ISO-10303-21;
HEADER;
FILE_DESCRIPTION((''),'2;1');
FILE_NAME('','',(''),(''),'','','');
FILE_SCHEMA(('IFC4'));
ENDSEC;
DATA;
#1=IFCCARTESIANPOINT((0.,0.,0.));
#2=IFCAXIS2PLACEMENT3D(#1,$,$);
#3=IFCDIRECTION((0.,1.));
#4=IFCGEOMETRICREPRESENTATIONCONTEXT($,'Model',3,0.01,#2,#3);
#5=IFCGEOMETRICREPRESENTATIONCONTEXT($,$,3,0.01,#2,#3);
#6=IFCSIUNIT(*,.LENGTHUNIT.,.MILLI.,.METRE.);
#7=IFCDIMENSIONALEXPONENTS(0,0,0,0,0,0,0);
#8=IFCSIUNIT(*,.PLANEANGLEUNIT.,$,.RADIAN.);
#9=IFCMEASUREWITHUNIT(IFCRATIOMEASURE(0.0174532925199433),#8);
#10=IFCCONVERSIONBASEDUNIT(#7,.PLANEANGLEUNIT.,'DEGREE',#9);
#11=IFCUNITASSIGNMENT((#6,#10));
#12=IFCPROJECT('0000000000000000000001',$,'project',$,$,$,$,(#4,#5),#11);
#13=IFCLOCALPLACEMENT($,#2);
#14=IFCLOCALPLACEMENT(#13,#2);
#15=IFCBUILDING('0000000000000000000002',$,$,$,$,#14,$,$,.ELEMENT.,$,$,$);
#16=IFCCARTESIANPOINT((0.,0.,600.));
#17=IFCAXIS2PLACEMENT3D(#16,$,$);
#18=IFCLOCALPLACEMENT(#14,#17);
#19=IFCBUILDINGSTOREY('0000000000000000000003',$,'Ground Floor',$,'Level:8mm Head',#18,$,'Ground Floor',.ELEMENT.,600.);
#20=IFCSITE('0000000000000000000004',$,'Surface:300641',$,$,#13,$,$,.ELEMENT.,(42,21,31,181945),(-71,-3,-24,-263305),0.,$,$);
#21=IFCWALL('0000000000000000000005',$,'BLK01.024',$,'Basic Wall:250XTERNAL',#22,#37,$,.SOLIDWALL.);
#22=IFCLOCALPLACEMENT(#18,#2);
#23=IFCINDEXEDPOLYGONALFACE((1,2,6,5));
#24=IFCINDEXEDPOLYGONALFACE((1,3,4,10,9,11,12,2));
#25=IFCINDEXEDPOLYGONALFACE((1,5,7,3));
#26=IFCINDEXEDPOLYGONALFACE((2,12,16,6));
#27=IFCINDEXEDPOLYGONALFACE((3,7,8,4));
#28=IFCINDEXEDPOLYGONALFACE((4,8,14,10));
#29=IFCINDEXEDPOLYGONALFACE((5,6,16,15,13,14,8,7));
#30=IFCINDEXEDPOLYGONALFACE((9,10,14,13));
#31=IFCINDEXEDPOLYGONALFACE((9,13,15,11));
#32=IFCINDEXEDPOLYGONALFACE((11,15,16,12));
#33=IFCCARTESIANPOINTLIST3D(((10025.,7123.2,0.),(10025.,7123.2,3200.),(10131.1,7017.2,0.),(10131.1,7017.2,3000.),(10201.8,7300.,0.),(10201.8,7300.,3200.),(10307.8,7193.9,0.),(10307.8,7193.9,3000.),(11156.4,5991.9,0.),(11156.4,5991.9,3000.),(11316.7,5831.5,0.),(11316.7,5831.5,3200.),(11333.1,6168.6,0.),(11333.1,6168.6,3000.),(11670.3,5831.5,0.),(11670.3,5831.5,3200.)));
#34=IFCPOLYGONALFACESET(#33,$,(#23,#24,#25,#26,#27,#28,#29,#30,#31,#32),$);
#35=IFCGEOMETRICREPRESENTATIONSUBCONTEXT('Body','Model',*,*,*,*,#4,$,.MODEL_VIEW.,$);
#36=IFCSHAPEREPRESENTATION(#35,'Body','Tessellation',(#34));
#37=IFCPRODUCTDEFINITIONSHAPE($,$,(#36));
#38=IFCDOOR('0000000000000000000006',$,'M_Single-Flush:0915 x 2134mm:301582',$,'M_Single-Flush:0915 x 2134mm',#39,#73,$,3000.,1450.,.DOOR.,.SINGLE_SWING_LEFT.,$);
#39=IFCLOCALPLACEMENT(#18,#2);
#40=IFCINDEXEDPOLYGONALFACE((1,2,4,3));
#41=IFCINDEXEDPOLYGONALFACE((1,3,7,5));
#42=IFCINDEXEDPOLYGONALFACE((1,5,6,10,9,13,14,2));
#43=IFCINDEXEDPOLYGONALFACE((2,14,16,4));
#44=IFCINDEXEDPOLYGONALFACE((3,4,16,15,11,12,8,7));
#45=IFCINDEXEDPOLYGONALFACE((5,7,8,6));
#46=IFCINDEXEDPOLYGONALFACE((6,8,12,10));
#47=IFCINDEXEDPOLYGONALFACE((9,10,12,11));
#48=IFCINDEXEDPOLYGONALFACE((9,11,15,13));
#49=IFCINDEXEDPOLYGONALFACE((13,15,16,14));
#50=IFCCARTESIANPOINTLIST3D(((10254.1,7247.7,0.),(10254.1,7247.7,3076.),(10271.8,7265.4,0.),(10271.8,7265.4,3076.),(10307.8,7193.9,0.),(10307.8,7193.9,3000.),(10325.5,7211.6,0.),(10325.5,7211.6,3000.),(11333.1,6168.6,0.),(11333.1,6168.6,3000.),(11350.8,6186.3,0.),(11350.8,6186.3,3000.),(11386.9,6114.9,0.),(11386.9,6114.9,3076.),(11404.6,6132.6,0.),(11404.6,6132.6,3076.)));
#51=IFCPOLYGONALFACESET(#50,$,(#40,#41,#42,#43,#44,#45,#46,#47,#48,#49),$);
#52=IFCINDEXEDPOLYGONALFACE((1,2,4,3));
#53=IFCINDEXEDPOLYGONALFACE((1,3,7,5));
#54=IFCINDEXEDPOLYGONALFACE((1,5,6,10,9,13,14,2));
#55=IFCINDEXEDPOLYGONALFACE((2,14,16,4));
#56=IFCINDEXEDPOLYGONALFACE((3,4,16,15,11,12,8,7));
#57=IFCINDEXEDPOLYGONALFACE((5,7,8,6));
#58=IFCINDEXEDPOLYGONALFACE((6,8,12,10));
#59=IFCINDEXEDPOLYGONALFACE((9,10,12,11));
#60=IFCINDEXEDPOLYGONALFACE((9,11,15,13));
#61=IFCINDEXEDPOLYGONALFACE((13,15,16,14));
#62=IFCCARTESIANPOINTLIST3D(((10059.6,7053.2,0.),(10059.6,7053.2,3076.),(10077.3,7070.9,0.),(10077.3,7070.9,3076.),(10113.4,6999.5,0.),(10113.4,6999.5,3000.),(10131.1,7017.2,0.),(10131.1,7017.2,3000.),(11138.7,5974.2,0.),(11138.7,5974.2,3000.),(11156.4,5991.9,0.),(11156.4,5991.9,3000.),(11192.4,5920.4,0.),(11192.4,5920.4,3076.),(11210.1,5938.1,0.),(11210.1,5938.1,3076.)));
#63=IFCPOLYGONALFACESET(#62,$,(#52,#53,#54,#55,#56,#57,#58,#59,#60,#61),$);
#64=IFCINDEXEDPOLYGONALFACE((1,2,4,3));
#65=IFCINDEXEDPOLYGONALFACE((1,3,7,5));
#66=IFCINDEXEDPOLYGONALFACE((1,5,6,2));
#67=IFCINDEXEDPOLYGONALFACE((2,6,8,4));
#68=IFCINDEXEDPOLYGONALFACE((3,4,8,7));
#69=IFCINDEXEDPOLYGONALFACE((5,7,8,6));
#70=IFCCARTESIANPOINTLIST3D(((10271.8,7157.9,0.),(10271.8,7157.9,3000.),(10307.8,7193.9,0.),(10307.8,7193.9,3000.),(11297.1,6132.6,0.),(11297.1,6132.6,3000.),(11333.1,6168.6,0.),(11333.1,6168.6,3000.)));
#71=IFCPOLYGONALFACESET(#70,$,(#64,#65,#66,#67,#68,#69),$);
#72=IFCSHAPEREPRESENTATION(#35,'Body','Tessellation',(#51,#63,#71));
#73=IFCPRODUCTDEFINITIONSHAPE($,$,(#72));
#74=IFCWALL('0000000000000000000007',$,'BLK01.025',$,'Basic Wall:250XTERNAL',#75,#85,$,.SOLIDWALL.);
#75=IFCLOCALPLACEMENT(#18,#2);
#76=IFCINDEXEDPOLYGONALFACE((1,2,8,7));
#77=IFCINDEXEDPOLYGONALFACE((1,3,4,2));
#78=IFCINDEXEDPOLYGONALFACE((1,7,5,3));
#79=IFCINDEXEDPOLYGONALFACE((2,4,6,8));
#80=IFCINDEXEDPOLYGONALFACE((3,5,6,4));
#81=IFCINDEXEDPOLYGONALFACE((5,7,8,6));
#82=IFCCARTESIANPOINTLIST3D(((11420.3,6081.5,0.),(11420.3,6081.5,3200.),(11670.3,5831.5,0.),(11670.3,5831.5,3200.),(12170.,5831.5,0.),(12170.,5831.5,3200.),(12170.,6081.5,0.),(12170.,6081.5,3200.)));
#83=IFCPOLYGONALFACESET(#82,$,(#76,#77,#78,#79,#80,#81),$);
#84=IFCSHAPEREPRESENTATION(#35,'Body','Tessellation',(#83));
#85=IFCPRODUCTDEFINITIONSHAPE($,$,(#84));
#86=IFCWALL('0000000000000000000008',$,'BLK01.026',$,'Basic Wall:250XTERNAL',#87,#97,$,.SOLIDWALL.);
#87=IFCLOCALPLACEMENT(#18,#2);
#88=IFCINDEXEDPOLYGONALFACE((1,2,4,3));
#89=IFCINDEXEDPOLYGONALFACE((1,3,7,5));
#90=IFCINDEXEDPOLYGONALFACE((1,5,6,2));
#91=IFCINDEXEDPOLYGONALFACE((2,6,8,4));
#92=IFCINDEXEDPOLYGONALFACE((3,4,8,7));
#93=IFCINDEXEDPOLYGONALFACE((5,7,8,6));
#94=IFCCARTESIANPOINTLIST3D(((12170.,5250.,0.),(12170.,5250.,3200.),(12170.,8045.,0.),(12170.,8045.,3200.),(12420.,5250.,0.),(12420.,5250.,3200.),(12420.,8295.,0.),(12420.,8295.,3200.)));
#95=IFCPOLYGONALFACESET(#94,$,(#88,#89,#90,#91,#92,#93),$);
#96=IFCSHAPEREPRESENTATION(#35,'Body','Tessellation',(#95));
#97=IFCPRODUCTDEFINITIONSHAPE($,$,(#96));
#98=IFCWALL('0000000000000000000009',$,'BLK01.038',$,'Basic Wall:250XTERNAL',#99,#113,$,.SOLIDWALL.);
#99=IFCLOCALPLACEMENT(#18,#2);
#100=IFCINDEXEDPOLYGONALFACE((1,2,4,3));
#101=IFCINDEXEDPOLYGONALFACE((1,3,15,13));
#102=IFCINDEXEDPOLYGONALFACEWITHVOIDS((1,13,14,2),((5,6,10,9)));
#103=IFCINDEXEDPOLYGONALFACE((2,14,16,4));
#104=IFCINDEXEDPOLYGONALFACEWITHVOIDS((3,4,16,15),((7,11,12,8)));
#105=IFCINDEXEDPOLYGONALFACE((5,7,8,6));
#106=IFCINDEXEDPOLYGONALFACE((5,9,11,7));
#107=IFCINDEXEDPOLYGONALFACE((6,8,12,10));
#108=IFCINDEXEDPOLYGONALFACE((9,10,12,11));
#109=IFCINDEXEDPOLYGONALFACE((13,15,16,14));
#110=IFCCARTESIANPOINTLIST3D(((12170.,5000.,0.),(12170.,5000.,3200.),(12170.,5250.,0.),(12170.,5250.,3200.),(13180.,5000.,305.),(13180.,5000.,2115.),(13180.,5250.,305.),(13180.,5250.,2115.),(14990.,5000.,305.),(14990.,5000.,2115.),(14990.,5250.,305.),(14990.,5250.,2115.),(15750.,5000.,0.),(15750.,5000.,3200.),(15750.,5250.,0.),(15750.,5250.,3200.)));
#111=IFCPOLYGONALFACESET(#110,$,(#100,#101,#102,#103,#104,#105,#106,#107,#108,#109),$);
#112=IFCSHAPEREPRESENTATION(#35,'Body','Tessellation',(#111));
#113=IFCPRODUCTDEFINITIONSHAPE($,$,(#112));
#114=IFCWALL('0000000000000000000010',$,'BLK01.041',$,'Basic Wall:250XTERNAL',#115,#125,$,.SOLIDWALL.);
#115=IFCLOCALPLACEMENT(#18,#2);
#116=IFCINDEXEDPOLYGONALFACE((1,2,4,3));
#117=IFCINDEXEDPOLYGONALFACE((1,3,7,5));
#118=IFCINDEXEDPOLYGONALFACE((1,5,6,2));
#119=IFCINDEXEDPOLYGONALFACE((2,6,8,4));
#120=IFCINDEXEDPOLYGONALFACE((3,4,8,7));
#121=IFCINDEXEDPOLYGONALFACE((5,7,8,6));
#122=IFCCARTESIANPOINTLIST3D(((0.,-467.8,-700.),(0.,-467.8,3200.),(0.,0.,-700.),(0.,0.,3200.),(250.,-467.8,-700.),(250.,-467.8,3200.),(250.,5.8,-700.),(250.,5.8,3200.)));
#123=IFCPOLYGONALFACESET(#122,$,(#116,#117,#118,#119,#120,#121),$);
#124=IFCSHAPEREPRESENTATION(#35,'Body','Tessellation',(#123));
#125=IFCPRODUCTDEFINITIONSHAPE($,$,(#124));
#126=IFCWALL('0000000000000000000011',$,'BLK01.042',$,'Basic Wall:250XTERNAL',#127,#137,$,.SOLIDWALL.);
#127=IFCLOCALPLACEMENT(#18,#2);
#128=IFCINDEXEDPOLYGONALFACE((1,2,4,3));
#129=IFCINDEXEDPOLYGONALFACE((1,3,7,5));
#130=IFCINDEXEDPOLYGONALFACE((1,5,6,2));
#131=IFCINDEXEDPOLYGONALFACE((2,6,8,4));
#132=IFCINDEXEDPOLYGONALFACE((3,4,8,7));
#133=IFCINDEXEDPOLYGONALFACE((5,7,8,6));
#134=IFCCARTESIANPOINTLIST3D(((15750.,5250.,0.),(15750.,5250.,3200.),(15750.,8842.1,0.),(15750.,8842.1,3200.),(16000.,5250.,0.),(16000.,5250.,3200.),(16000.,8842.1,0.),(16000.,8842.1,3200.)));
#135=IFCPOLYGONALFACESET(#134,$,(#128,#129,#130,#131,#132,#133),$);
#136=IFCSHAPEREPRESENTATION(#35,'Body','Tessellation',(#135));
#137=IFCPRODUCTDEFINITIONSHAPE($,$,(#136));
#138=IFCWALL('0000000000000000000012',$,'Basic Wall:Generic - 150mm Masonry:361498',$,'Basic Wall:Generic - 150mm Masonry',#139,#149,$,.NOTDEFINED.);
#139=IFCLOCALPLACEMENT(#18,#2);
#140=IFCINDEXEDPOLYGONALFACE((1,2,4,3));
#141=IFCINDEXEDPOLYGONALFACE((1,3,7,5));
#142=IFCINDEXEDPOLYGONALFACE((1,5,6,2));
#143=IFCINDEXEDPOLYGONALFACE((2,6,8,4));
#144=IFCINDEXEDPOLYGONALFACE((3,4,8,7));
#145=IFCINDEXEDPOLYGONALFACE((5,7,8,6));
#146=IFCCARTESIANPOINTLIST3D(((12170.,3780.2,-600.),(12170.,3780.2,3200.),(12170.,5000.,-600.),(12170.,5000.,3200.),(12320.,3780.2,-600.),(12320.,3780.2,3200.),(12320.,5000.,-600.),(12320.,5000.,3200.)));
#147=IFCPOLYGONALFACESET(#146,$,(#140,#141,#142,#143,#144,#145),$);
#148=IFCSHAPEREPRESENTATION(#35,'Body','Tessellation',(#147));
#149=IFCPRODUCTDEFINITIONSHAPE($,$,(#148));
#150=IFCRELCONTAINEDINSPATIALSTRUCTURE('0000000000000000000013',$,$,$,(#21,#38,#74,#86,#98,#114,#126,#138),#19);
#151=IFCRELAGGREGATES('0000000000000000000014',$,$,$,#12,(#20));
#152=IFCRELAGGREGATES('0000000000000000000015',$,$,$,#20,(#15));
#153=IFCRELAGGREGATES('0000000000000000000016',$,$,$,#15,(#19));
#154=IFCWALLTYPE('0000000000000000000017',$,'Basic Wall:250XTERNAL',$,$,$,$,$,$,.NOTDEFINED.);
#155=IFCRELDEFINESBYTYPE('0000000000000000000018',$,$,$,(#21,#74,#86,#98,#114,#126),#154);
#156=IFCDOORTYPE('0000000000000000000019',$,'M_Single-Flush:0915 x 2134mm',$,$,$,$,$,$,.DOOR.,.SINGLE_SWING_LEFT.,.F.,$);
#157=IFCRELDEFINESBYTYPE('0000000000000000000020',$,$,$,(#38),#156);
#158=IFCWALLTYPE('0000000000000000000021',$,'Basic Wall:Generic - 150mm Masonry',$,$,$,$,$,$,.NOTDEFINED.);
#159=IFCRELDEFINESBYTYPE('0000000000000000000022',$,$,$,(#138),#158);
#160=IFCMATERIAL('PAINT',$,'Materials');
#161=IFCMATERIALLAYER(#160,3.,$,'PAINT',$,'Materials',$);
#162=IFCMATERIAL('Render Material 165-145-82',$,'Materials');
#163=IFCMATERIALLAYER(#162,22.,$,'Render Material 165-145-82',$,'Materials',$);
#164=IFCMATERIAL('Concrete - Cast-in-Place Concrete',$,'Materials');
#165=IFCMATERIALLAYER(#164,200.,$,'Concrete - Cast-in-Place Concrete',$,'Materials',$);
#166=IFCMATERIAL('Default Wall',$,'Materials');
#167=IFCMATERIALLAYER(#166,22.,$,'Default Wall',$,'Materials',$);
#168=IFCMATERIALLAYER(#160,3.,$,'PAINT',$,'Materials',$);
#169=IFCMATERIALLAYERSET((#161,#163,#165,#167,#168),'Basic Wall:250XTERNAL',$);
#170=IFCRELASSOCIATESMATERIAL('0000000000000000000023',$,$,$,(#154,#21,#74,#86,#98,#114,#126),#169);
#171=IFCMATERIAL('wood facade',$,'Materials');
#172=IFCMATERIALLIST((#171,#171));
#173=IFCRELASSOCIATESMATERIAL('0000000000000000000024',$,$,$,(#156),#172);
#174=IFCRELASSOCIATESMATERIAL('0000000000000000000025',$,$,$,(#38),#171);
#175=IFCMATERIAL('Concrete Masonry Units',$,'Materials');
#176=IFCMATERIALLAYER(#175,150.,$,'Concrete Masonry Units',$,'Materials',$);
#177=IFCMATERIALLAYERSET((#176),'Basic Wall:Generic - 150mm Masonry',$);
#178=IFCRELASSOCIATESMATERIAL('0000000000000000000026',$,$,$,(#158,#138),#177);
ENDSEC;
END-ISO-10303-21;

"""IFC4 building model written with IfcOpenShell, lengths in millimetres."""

from ifc_helpers import new_model, entity, si_unit, converted_unit, direction, frame, frame_2d, origin, place, context, subcontext, project, spatial, polyline, rectangle, outline, extrude, clip, halfspace, source, transform, mapped, material, material_list, layer, layer_set, layer_usage, type_object, type_shapes, element, fill, save


model = new_model("IFC4")

# Units and contexts
model_context = context("Model", 3, precision=0.01, world=origin(), true_north=direction((0.0, 1.0)))
context_of_model = context(None, 3, precision=0.01, world=origin(), true_north=direction((0.0, 1.0)))
body_context = subcontext(model_context, "Body", "Model", "MODEL_VIEW")
ifc_project = project(units=[si_unit("LENGTHUNIT", "METRE", prefix="MILLI"), converted_unit("PLANEANGLEUNIT", "DEGREE", entity("IfcRatioMeasure", 0.0174532925199433), si_unit("PLANEANGLEUNIT", "RADIAN"), dimensions=[0, 0, 0, 0, 0, 0, 0])], contexts=[model_context, context_of_model])

# Site, building, storey
site_placement = place(None, origin())
site = spatial("IfcSite", under=ifc_project, at=site_placement, Name="Surface:300641", CompositionType="ELEMENT", RefLatitude=(42, 21, 31, 181945), RefLongitude=(-71, -3, -24, -263305), RefElevation=0.0)
building_placement = place(site_placement, origin())
building = spatial("IfcBuilding", under=site, at=building_placement, CompositionType="ELEMENT")
storey_placement = place(building_placement, frame((0.0, 0.0, 600.0)))
storey = spatial("IfcBuildingStorey", under=building, at=storey_placement, Name="Ground Floor", ObjectType="Level:8mm Head", LongName="Ground Floor", CompositionType="ELEMENT", Elevation=600.0)

# Shared definitions
ifc_material_1 = material(Name="Concrete - Cast-in-Place Concrete", Category="Materials")

# Shared definitions
ifc_material_2 = material(Name="PAINT", Category="Materials")
ifc_layer_1 = layer(ifc_material_2, 3.0, Name="PAINT", Category="Materials")
ifc_material_3 = material(Name="Render Material 165-145-82", Category="Materials")
ifc_layer_2 = layer(ifc_material_3, 22.0, Name="Render Material 165-145-82", Category="Materials")
ifc_layer_3 = layer(ifc_material_1, 200.0, Name="Concrete - Cast-in-Place Concrete", Category="Materials")
ifc_material_4 = material(Name="Default Wall", Category="Materials")
ifc_layer_4 = layer(ifc_material_4, 22.0, Name="Default Wall", Category="Materials")
ifc_layer_5 = layer(ifc_material_2, 3.0, Name="PAINT", Category="Materials")
ifc_layer_set_1 = layer_set([ifc_layer_1, ifc_layer_2, ifc_layer_3, ifc_layer_4, ifc_layer_5], Name="Basic Wall:250XTERNAL")
wall_type_1 = type_object("IfcWallType", Name="Basic Wall:250XTERNAL", PredefinedType="NOTDEFINED", material=ifc_layer_set_1)

# Wall, opening, door
ifc_layer_usage_1 = layer_usage(ifc_layer_set_1, "AXIS2", "NEGATIVE", 125.0)
wall_1_placement = place(storey_placement, frame((10113.4, 7211.6, 0.0), z_axis=(0.0, 0.0, 1.0), x_axis=(0.707107, -0.707107, 0.0)))
wall_1 = element("IfcWall", 1, at=wall_1_placement, inside=storey, type_object=wall_type_1, material=ifc_layer_usage_1, Name="BLK01.024", ObjectType="Basic Wall:250XTERNAL", PredefinedType="SOLIDWALL", context=body_context, shape_type="Clipping", body=[
    clip(extrude(outline(polyline([(0.0, -125.0), (1826.8, -125.0), (2076.8, 125.0), (1723.2, 125.0), (0.0, 125.0), (0.0, -125.0)])), origin(), (0.0, 0.0, 1.0), 3200.0), halfspace(origin(), True)),
])
opening_1_placement = place(wall_1_placement, frame((150.0, -125.0, 0.0)))
opening_1 = element("IfcOpeningElement", 2, at=opening_1_placement, cuts=wall_1, ObjectType="Opening", PredefinedType="OPENING", context=body_context, shape_type="SweptSolid", body=[
    extrude(rectangle(XDim=1450.0, YDim=3000.0, at=frame_2d((1500.0, 725.0), x_axis=(0.0, -1.0))), frame((0.0, 0.0, 0.0), z_axis=(0.0, 1.0, 0.0), x_axis=(0.0, 0.0, 1.0)), (0.0, 0.0, 1.0), 250.0),
])
ifc_material_5 = material(Name="wood facade", Category="Materials")
ifc_material_list = material_list([ifc_material_5, ifc_material_5])
door_type = type_object("IfcDoorType", Name="M_Single-Flush:0915 x 2134mm", OperationType="SINGLE_SWING_LEFT", ParameterTakesPrecedence=False, PredefinedType="DOOR", material=ifc_material_list)
shared_shape_1 = source(origin(), body_context, "Body", "SweptSolid", [
    extrude(outline(polyline([(-801.0, -1557.0), (801.0, -1557.0), (801.0, 1519.0), (725.0, 1519.0), (725.0, -1481.0), (-725.0, -1481.0), (-725.0, 1519.0), (-801.0, 1519.0), (-801.0, -1557.0)])), frame((725.0, 275.0, 1519.0), z_axis=(0.0, -1.0, 0.0), x_axis=(-1.0, 0.0, 0.0)), (0.0, 0.0, 1.0), 25.0),
    extrude(outline(polyline([(-1557.0, -801.0), (1519.0, -801.0), (1519.0, -725.0), (-1481.0, -725.0), (-1481.0, 725.0), (1519.0, 725.0), (1519.0, 801.0), (-1557.0, 801.0), (-1557.0, -801.0)])), frame((725.0, 0.0, 1519.0), z_axis=(0.0, -1.0, 0.0), x_axis=(0.0, 0.0, -1.0)), (0.0, 0.0, 1.0), 25.0),
    extrude(rectangle(XDim=1450.0, YDim=51.0, at=frame_2d((0.0, 0.0), x_axis=(1.0, 0.0))), frame((725.0, 224.5, 0.0)), (0.0, 0.0, 1.0), 3000.0),
])
type_shapes(door_type, [shared_shape_1])
door_placement = place(opening_1_placement, origin())
door = element("IfcDoor", 3, at=door_placement, inside=storey, type_object=door_type, material=ifc_material_5, Name="M_Single-Flush:0915 x 2134mm:301582", ObjectType="M_Single-Flush:0915 x 2134mm", OperationType="SINGLE_SWING_LEFT", OverallHeight=3000.0, OverallWidth=1450.0, PredefinedType="DOOR", context=body_context, shape_type="MappedRepresentation", body=[
    mapped(shared_shape_1, transform((0.0, 0.0, 0.0), scale=1.0)),
])
fill(opening_1, door)

# Walls
ifc_layer_usage_2 = layer_usage(ifc_layer_set_1, "AXIS2", "NEGATIVE", 125.0)
wall_2_placement = place(storey_placement, frame((11420.3, 5956.5, 0.0)))
element("IfcWall", 4, at=wall_2_placement, inside=storey, type_object=wall_type_1, material=ifc_layer_usage_2, Name="BLK01.025", ObjectType="Basic Wall:250XTERNAL", PredefinedType="SOLIDWALL", context=body_context, shape_type="Clipping", body=[
    clip(extrude(outline(polyline([(749.7, -125.0), (749.7, 125.0), (0.0, 125.0), (250.0, -125.0), (749.7, -125.0)])), origin(), (0.0, 0.0, 1.0), 3200.0), halfspace(origin(), True)),
])
ifc_layer_usage_3 = layer_usage(ifc_layer_set_1, "AXIS2", "NEGATIVE", 125.0)
wall_3_placement = place(storey_placement, frame((12295.0, 5250.0, 0.0), z_axis=(0.0, 0.0, 1.0), x_axis=(0.0, 1.0, 0.0)))
element("IfcWall", 5, at=wall_3_placement, inside=storey, type_object=wall_type_1, material=ifc_layer_usage_3, Name="BLK01.026", ObjectType="Basic Wall:250XTERNAL", PredefinedType="SOLIDWALL", context=body_context, shape_type="Clipping", body=[
    clip(extrude(outline(polyline([(3045.0, -125.0), (2795.0, 125.0), (831.5, 125.0), (581.5, 125.0), (0.0, 125.0), (0.0, -125.0), (2691.4, -125.0), (3045.0, -125.0)])), origin(), (0.0, 0.0, 1.0), 3200.0), halfspace(origin(), True)),
])

# Wall, opening
ifc_layer_usage_4 = layer_usage(ifc_layer_set_1, "AXIS2", "NEGATIVE", 125.0)
wall_4_placement = place(storey_placement, frame((12170.0, 5125.0, 0.0)))
wall_4 = element("IfcWall", 6, at=wall_4_placement, inside=storey, type_object=wall_type_1, material=ifc_layer_usage_4, Name="BLK01.038", ObjectType="Basic Wall:250XTERNAL", PredefinedType="SOLIDWALL", context=body_context, shape_type="Clipping", body=[
    clip(extrude(rectangle(XDim=3580.0, YDim=250.0, at=frame_2d((1790.0, 0.0), x_axis=(-1.0, 0.0))), origin(), (0.0, 0.0, 1.0), 3200.0), halfspace(origin(), True)),
])
opening_2_placement = place(wall_4_placement, frame((1010.0, -125.0, 305.0)))
element("IfcOpeningElement", 7, at=opening_2_placement, cuts=wall_4, ObjectType="Opening", PredefinedType="OPENING", context=body_context, shape_type="SweptSolid", body=[
    extrude(rectangle(XDim=1810.0, YDim=1810.0, at=frame_2d((905.0, 905.0), x_axis=(-1.0, 0.0))), frame((0.0, 0.0, 0.0), z_axis=(0.0, 1.0, 0.0), x_axis=(0.0, 0.0, 1.0)), (0.0, 0.0, 1.0), 250.0),
])

# Walls
ifc_layer_usage_5 = layer_usage(ifc_layer_set_1, "AXIS2", "NEGATIVE", 125.0)
wall_5_placement = place(storey_placement, frame((125.0, 5.8, -700.0), z_axis=(0.0, 0.0, 1.0), x_axis=(0.0, -1.0, 0.0)))
element("IfcWall", 8, at=wall_5_placement, inside=storey, type_object=wall_type_1, material=ifc_layer_usage_5, Name="BLK01.041", ObjectType="Basic Wall:250XTERNAL", PredefinedType="SOLIDWALL", context=body_context, shape_type="SweptSolid", body=[
    extrude(outline(polyline([(473.5, -125.0), (473.5, 125.0), (0.0, 125.0), (5.8, -125.0), (473.5, -125.0)])), origin(), (0.0, 0.0, 1.0), 3900.0),
])
ifc_layer_usage_6 = layer_usage(ifc_layer_set_1, "AXIS2", "NEGATIVE", 125.0)
wall_6_placement = place(storey_placement, frame((15875.0, 5250.0, 0.0), z_axis=(0.0, 0.0, 1.0), x_axis=(0.0, 1.0, 0.0)))
element("IfcWall", 9, at=wall_6_placement, inside=storey, type_object=wall_type_1, material=ifc_layer_usage_6, Name="BLK01.042", ObjectType="Basic Wall:250XTERNAL", PredefinedType="SOLIDWALL", context=body_context, shape_type="Clipping", body=[
    clip(extrude(rectangle(XDim=3592.1, YDim=250.0, at=frame_2d((1796.1, 0.0), x_axis=(-1.0, 0.0))), origin(), (0.0, 0.0, 1.0), 3200.0), halfspace(origin(), True)),
])
ifc_material_6 = material(Name="Concrete Masonry Units", Category="Materials")
ifc_layer_6 = layer(ifc_material_6, 150.0, Name="Concrete Masonry Units", Category="Materials")
ifc_layer_set_2 = layer_set([ifc_layer_6], Name="Basic Wall:Generic - 150mm Masonry")
ifc_layer_usage_7 = layer_usage(ifc_layer_set_2, "AXIS2", "NEGATIVE", 75.0)
wall_type_2 = type_object("IfcWallType", Name="Basic Wall:Generic - 150mm Masonry", PredefinedType="NOTDEFINED", material=ifc_layer_set_2)
wall_7_placement = place(storey_placement, frame((12245.0, 5000.0, -600.0), z_axis=(0.0, 0.0, 1.0), x_axis=(0.0, -1.0, 0.0)))
element("IfcWall", 10, at=wall_7_placement, inside=storey, type_object=wall_type_2, material=ifc_layer_usage_7, Name="Basic Wall:Generic - 150mm Masonry:361498", ObjectType="Basic Wall:Generic - 150mm Masonry", PredefinedType="NOTDEFINED", context=body_context, shape_type="Clipping", body=[
    clip(extrude(rectangle(XDim=1219.8, YDim=150.0, at=frame_2d((609.9, 0.0), x_axis=(-1.0, 0.0))), origin(), (0.0, 0.0, 1.0), 3800.0), halfspace(frame((0.0, 0.0, -600.0)), True)),
])

save(model, "model.ifc")
